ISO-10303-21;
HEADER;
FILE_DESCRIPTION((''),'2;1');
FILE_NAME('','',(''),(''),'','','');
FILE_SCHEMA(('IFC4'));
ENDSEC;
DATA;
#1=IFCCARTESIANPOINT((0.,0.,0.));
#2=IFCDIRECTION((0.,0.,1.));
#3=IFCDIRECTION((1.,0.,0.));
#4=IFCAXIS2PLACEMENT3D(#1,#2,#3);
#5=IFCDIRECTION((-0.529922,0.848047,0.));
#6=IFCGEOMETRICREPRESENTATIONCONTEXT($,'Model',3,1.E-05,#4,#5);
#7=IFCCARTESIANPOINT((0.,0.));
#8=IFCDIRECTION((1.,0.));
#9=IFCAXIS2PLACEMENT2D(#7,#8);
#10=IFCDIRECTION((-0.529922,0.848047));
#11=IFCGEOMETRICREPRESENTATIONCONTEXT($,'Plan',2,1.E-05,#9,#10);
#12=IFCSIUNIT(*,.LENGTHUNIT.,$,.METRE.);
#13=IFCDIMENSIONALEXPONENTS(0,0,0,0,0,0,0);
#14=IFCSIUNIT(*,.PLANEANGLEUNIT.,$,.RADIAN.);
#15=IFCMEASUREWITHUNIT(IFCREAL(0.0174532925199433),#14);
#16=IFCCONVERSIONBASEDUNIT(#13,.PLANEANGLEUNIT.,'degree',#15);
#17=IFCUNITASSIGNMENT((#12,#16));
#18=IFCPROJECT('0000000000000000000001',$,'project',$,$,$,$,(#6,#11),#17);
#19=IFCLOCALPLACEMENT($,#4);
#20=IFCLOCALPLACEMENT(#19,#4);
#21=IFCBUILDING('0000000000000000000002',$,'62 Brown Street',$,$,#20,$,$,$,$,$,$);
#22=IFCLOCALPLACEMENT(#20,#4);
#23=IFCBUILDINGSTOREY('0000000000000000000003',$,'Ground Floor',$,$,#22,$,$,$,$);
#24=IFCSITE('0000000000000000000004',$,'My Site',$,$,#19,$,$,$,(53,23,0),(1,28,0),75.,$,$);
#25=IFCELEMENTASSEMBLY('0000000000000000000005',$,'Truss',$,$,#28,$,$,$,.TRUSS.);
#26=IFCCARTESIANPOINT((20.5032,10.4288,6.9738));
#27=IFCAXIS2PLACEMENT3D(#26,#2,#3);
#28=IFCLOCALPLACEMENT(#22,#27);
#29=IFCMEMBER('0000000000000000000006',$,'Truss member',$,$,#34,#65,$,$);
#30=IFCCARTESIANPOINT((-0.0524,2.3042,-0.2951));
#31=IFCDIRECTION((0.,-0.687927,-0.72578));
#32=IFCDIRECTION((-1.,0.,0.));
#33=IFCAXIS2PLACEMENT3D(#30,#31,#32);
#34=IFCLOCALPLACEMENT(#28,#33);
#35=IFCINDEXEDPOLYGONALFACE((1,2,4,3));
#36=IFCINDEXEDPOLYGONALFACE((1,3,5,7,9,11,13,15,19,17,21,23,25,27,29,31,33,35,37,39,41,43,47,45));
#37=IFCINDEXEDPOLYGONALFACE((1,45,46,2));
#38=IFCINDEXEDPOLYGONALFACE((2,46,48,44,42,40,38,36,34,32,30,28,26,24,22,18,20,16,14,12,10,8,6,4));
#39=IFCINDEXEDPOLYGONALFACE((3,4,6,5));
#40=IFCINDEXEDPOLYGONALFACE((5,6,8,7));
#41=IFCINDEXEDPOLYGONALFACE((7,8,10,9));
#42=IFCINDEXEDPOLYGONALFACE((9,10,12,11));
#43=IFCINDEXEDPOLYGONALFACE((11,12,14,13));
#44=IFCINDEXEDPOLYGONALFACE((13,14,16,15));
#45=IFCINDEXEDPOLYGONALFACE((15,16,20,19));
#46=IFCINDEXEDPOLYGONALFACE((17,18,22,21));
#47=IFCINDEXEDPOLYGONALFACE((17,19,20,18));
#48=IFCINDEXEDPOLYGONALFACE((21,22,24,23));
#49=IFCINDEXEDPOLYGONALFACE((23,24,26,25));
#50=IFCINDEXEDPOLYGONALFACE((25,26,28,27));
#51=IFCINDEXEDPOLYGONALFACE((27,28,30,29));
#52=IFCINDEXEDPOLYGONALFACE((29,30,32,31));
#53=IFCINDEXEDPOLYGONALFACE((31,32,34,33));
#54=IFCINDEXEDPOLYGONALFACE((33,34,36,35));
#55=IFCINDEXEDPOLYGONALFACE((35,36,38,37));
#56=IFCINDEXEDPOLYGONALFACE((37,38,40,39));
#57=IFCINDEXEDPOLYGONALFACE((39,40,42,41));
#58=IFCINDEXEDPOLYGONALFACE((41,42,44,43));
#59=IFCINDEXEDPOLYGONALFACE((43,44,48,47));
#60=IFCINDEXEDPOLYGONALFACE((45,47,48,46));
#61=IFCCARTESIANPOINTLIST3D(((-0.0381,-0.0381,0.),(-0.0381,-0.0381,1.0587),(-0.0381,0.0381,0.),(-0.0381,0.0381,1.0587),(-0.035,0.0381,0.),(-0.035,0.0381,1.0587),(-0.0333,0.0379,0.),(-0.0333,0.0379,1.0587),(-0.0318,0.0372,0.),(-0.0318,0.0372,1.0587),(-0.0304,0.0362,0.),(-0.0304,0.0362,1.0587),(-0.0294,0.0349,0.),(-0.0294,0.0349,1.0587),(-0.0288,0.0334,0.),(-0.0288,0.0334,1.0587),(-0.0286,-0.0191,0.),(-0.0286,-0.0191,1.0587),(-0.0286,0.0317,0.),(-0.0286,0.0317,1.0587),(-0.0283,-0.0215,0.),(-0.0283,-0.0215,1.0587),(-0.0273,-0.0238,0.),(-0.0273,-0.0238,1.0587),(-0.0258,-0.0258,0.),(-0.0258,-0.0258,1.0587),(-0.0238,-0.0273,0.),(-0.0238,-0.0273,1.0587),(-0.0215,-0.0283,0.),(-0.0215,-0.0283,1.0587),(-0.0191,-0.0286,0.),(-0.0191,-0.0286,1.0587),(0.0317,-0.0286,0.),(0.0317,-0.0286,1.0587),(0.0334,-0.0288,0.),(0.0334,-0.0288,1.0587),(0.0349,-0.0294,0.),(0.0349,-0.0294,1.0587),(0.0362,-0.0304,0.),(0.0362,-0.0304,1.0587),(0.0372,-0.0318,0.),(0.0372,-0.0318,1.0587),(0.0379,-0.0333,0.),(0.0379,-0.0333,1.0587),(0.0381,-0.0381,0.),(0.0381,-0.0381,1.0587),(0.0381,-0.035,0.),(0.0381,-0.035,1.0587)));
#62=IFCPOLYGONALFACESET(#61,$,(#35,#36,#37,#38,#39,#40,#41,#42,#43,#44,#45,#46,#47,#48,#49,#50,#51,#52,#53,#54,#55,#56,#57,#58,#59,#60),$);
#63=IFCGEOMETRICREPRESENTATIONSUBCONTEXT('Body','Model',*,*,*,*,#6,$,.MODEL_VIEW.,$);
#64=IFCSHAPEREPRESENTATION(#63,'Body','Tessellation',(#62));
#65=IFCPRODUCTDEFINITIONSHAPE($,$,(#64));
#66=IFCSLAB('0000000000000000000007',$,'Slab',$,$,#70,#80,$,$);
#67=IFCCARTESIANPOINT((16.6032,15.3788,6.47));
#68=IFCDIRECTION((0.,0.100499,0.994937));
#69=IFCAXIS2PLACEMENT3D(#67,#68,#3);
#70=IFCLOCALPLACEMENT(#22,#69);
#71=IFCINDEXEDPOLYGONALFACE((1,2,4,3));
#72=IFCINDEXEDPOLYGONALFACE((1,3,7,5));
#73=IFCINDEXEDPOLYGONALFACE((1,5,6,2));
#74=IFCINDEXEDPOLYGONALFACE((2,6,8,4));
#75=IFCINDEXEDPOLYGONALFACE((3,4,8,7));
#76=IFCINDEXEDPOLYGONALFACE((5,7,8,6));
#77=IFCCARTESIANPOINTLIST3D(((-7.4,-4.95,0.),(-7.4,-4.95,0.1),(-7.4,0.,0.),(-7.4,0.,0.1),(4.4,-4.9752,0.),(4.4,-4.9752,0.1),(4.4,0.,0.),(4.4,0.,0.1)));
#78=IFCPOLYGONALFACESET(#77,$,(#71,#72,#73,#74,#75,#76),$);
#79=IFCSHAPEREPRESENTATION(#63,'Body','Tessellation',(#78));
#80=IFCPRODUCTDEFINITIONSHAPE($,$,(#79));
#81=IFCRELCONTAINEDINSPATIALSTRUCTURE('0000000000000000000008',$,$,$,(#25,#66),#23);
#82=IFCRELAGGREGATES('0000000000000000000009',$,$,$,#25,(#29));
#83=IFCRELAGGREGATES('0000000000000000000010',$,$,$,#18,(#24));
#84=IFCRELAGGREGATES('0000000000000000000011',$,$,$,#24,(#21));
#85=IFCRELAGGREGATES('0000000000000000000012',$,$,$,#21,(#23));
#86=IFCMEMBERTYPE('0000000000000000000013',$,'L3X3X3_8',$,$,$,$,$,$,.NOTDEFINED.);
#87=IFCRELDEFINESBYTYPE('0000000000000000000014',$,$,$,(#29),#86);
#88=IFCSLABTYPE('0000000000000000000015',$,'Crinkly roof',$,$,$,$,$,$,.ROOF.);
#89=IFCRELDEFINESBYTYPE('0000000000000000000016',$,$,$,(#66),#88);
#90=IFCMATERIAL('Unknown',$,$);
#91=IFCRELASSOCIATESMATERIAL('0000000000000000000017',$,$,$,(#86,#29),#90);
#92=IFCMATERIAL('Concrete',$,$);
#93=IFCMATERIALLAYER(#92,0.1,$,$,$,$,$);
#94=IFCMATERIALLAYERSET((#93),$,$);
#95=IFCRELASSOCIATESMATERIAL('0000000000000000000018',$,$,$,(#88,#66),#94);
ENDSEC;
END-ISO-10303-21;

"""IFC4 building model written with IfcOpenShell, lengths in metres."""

from ifc_helpers import new_model, entity, si_unit, converted_unit, direction, frame, origin_with_axes, origin_2d_with_axis, place, context, subcontext, project, spatial, indexed_curve, l_section, outline, extrude, material, layer, layer_set, layer_usage, material_profile, profile_set, profile_usage, type_object, element, aggregate, save


model = new_model("IFC4")

# Units and contexts
model_context = context("Model", 3, precision=1e-05, world=origin_with_axes(), true_north=direction((-0.529922, 0.848047, 0.0)))
plan_context = context("Plan", 2, precision=1e-05, world=origin_2d_with_axis(), true_north=direction((-0.529922, 0.848047)))
body_context = subcontext(model_context, "Body", "Model", "MODEL_VIEW")
ifc_project = project(units=[si_unit("LENGTHUNIT", "METRE"), converted_unit("PLANEANGLEUNIT", "degree", entity("IfcReal", 0.0174532925199433), si_unit("PLANEANGLEUNIT", "RADIAN"), dimensions=[0, 0, 0, 0, 0, 0, 0])], contexts=[model_context, plan_context])

# Site, building, storey
site_placement = place(None, origin_with_axes())
site = spatial("IfcSite", under=ifc_project, at=site_placement, Name="My Site", RefLatitude=(53, 23, 0), RefLongitude=(1, 28, 0), RefElevation=75.0)
building_placement = place(site_placement, origin_with_axes())
building = spatial("IfcBuilding", under=site, at=building_placement, Name="62 Brown Street")
storey_placement = place(building_placement, origin_with_axes())
storey = spatial("IfcBuildingStorey", under=building, at=storey_placement, Name="Ground Floor")

# Element assembly, member
assembly_1_placement = place(storey_placement, frame((20.5032, 10.4288, 6.9738), z_axis=(0.0, 0.0, 1.0), x_axis=(1.0, 0.0, 0.0)))
assembly_1 = element("IfcElementAssembly", 1, at=assembly_1_placement, inside=storey, Name="Truss", PredefinedType="TRUSS")
ifc_material_1 = material(Name="Unknown")
ifc_material_profile_1 = material_profile(ifc_material_1, l_section(Depth=0.0762, Width=0.0762, Thickness=0.0095, FilletRadius=0.0095, EdgeRadius=0.0064))
ifc_profile_set_1 = profile_set([ifc_material_profile_1])
member_type_1 = type_object("IfcMemberType", Name="L3X3X3_8", PredefinedType="NOTDEFINED", material=ifc_profile_set_1)
ifc_profile_usage_1 = profile_usage(ifc_profile_set_1, cardinal=5)
member_1_placement = place(assembly_1_placement, frame((-0.0524, 2.3042, -0.2951), z_axis=(0.0, -0.687927, -0.72578), x_axis=(-1.0, 0.0, 0.0)))
member_1 = element("IfcMember", 2, at=member_1_placement, type_object=member_type_1, material=ifc_profile_usage_1, Name="Truss member", context=body_context, shape_type="SweptSolid", body=[
    extrude(l_section(Depth=0.0762, Width=0.0762, Thickness=0.0095, FilletRadius=0.0095, EdgeRadius=0.0064), origin_with_axes(), (0.0, 0.0, 1.0), 1.0587),
])
aggregate(assembly_1, [member_1])

# Slab
ifc_material_2 = material(Name="Concrete")
ifc_layer = layer(ifc_material_2, 0.1)
ifc_layer_set = layer_set([ifc_layer])
ifc_layer_usage = layer_usage(ifc_layer_set, "AXIS3", "POSITIVE", 0.0)
slab_type = type_object("IfcSlabType", Name="Crinkly roof", PredefinedType="ROOF", material=ifc_layer_set)
slab_placement = place(storey_placement, frame((16.6032, 15.3788, 6.47), z_axis=(0.0, 0.100499, 0.994937), x_axis=(1.0, 0.0, 0.0)))
element("IfcSlab", 3, at=slab_placement, inside=storey, type_object=slab_type, material=ifc_layer_usage, Name="Slab", context=body_context, shape_type="SweptSolid", body=[
    extrude(outline(indexed_curve([(4.4, 0.0), (-7.4, 0.0), (-7.4, -4.95), (4.4, -4.9752), (4.4, 0.0)])), None, (0.0, 0.0, 1.0), 0.1),
])

save(model, "model.ifc")
